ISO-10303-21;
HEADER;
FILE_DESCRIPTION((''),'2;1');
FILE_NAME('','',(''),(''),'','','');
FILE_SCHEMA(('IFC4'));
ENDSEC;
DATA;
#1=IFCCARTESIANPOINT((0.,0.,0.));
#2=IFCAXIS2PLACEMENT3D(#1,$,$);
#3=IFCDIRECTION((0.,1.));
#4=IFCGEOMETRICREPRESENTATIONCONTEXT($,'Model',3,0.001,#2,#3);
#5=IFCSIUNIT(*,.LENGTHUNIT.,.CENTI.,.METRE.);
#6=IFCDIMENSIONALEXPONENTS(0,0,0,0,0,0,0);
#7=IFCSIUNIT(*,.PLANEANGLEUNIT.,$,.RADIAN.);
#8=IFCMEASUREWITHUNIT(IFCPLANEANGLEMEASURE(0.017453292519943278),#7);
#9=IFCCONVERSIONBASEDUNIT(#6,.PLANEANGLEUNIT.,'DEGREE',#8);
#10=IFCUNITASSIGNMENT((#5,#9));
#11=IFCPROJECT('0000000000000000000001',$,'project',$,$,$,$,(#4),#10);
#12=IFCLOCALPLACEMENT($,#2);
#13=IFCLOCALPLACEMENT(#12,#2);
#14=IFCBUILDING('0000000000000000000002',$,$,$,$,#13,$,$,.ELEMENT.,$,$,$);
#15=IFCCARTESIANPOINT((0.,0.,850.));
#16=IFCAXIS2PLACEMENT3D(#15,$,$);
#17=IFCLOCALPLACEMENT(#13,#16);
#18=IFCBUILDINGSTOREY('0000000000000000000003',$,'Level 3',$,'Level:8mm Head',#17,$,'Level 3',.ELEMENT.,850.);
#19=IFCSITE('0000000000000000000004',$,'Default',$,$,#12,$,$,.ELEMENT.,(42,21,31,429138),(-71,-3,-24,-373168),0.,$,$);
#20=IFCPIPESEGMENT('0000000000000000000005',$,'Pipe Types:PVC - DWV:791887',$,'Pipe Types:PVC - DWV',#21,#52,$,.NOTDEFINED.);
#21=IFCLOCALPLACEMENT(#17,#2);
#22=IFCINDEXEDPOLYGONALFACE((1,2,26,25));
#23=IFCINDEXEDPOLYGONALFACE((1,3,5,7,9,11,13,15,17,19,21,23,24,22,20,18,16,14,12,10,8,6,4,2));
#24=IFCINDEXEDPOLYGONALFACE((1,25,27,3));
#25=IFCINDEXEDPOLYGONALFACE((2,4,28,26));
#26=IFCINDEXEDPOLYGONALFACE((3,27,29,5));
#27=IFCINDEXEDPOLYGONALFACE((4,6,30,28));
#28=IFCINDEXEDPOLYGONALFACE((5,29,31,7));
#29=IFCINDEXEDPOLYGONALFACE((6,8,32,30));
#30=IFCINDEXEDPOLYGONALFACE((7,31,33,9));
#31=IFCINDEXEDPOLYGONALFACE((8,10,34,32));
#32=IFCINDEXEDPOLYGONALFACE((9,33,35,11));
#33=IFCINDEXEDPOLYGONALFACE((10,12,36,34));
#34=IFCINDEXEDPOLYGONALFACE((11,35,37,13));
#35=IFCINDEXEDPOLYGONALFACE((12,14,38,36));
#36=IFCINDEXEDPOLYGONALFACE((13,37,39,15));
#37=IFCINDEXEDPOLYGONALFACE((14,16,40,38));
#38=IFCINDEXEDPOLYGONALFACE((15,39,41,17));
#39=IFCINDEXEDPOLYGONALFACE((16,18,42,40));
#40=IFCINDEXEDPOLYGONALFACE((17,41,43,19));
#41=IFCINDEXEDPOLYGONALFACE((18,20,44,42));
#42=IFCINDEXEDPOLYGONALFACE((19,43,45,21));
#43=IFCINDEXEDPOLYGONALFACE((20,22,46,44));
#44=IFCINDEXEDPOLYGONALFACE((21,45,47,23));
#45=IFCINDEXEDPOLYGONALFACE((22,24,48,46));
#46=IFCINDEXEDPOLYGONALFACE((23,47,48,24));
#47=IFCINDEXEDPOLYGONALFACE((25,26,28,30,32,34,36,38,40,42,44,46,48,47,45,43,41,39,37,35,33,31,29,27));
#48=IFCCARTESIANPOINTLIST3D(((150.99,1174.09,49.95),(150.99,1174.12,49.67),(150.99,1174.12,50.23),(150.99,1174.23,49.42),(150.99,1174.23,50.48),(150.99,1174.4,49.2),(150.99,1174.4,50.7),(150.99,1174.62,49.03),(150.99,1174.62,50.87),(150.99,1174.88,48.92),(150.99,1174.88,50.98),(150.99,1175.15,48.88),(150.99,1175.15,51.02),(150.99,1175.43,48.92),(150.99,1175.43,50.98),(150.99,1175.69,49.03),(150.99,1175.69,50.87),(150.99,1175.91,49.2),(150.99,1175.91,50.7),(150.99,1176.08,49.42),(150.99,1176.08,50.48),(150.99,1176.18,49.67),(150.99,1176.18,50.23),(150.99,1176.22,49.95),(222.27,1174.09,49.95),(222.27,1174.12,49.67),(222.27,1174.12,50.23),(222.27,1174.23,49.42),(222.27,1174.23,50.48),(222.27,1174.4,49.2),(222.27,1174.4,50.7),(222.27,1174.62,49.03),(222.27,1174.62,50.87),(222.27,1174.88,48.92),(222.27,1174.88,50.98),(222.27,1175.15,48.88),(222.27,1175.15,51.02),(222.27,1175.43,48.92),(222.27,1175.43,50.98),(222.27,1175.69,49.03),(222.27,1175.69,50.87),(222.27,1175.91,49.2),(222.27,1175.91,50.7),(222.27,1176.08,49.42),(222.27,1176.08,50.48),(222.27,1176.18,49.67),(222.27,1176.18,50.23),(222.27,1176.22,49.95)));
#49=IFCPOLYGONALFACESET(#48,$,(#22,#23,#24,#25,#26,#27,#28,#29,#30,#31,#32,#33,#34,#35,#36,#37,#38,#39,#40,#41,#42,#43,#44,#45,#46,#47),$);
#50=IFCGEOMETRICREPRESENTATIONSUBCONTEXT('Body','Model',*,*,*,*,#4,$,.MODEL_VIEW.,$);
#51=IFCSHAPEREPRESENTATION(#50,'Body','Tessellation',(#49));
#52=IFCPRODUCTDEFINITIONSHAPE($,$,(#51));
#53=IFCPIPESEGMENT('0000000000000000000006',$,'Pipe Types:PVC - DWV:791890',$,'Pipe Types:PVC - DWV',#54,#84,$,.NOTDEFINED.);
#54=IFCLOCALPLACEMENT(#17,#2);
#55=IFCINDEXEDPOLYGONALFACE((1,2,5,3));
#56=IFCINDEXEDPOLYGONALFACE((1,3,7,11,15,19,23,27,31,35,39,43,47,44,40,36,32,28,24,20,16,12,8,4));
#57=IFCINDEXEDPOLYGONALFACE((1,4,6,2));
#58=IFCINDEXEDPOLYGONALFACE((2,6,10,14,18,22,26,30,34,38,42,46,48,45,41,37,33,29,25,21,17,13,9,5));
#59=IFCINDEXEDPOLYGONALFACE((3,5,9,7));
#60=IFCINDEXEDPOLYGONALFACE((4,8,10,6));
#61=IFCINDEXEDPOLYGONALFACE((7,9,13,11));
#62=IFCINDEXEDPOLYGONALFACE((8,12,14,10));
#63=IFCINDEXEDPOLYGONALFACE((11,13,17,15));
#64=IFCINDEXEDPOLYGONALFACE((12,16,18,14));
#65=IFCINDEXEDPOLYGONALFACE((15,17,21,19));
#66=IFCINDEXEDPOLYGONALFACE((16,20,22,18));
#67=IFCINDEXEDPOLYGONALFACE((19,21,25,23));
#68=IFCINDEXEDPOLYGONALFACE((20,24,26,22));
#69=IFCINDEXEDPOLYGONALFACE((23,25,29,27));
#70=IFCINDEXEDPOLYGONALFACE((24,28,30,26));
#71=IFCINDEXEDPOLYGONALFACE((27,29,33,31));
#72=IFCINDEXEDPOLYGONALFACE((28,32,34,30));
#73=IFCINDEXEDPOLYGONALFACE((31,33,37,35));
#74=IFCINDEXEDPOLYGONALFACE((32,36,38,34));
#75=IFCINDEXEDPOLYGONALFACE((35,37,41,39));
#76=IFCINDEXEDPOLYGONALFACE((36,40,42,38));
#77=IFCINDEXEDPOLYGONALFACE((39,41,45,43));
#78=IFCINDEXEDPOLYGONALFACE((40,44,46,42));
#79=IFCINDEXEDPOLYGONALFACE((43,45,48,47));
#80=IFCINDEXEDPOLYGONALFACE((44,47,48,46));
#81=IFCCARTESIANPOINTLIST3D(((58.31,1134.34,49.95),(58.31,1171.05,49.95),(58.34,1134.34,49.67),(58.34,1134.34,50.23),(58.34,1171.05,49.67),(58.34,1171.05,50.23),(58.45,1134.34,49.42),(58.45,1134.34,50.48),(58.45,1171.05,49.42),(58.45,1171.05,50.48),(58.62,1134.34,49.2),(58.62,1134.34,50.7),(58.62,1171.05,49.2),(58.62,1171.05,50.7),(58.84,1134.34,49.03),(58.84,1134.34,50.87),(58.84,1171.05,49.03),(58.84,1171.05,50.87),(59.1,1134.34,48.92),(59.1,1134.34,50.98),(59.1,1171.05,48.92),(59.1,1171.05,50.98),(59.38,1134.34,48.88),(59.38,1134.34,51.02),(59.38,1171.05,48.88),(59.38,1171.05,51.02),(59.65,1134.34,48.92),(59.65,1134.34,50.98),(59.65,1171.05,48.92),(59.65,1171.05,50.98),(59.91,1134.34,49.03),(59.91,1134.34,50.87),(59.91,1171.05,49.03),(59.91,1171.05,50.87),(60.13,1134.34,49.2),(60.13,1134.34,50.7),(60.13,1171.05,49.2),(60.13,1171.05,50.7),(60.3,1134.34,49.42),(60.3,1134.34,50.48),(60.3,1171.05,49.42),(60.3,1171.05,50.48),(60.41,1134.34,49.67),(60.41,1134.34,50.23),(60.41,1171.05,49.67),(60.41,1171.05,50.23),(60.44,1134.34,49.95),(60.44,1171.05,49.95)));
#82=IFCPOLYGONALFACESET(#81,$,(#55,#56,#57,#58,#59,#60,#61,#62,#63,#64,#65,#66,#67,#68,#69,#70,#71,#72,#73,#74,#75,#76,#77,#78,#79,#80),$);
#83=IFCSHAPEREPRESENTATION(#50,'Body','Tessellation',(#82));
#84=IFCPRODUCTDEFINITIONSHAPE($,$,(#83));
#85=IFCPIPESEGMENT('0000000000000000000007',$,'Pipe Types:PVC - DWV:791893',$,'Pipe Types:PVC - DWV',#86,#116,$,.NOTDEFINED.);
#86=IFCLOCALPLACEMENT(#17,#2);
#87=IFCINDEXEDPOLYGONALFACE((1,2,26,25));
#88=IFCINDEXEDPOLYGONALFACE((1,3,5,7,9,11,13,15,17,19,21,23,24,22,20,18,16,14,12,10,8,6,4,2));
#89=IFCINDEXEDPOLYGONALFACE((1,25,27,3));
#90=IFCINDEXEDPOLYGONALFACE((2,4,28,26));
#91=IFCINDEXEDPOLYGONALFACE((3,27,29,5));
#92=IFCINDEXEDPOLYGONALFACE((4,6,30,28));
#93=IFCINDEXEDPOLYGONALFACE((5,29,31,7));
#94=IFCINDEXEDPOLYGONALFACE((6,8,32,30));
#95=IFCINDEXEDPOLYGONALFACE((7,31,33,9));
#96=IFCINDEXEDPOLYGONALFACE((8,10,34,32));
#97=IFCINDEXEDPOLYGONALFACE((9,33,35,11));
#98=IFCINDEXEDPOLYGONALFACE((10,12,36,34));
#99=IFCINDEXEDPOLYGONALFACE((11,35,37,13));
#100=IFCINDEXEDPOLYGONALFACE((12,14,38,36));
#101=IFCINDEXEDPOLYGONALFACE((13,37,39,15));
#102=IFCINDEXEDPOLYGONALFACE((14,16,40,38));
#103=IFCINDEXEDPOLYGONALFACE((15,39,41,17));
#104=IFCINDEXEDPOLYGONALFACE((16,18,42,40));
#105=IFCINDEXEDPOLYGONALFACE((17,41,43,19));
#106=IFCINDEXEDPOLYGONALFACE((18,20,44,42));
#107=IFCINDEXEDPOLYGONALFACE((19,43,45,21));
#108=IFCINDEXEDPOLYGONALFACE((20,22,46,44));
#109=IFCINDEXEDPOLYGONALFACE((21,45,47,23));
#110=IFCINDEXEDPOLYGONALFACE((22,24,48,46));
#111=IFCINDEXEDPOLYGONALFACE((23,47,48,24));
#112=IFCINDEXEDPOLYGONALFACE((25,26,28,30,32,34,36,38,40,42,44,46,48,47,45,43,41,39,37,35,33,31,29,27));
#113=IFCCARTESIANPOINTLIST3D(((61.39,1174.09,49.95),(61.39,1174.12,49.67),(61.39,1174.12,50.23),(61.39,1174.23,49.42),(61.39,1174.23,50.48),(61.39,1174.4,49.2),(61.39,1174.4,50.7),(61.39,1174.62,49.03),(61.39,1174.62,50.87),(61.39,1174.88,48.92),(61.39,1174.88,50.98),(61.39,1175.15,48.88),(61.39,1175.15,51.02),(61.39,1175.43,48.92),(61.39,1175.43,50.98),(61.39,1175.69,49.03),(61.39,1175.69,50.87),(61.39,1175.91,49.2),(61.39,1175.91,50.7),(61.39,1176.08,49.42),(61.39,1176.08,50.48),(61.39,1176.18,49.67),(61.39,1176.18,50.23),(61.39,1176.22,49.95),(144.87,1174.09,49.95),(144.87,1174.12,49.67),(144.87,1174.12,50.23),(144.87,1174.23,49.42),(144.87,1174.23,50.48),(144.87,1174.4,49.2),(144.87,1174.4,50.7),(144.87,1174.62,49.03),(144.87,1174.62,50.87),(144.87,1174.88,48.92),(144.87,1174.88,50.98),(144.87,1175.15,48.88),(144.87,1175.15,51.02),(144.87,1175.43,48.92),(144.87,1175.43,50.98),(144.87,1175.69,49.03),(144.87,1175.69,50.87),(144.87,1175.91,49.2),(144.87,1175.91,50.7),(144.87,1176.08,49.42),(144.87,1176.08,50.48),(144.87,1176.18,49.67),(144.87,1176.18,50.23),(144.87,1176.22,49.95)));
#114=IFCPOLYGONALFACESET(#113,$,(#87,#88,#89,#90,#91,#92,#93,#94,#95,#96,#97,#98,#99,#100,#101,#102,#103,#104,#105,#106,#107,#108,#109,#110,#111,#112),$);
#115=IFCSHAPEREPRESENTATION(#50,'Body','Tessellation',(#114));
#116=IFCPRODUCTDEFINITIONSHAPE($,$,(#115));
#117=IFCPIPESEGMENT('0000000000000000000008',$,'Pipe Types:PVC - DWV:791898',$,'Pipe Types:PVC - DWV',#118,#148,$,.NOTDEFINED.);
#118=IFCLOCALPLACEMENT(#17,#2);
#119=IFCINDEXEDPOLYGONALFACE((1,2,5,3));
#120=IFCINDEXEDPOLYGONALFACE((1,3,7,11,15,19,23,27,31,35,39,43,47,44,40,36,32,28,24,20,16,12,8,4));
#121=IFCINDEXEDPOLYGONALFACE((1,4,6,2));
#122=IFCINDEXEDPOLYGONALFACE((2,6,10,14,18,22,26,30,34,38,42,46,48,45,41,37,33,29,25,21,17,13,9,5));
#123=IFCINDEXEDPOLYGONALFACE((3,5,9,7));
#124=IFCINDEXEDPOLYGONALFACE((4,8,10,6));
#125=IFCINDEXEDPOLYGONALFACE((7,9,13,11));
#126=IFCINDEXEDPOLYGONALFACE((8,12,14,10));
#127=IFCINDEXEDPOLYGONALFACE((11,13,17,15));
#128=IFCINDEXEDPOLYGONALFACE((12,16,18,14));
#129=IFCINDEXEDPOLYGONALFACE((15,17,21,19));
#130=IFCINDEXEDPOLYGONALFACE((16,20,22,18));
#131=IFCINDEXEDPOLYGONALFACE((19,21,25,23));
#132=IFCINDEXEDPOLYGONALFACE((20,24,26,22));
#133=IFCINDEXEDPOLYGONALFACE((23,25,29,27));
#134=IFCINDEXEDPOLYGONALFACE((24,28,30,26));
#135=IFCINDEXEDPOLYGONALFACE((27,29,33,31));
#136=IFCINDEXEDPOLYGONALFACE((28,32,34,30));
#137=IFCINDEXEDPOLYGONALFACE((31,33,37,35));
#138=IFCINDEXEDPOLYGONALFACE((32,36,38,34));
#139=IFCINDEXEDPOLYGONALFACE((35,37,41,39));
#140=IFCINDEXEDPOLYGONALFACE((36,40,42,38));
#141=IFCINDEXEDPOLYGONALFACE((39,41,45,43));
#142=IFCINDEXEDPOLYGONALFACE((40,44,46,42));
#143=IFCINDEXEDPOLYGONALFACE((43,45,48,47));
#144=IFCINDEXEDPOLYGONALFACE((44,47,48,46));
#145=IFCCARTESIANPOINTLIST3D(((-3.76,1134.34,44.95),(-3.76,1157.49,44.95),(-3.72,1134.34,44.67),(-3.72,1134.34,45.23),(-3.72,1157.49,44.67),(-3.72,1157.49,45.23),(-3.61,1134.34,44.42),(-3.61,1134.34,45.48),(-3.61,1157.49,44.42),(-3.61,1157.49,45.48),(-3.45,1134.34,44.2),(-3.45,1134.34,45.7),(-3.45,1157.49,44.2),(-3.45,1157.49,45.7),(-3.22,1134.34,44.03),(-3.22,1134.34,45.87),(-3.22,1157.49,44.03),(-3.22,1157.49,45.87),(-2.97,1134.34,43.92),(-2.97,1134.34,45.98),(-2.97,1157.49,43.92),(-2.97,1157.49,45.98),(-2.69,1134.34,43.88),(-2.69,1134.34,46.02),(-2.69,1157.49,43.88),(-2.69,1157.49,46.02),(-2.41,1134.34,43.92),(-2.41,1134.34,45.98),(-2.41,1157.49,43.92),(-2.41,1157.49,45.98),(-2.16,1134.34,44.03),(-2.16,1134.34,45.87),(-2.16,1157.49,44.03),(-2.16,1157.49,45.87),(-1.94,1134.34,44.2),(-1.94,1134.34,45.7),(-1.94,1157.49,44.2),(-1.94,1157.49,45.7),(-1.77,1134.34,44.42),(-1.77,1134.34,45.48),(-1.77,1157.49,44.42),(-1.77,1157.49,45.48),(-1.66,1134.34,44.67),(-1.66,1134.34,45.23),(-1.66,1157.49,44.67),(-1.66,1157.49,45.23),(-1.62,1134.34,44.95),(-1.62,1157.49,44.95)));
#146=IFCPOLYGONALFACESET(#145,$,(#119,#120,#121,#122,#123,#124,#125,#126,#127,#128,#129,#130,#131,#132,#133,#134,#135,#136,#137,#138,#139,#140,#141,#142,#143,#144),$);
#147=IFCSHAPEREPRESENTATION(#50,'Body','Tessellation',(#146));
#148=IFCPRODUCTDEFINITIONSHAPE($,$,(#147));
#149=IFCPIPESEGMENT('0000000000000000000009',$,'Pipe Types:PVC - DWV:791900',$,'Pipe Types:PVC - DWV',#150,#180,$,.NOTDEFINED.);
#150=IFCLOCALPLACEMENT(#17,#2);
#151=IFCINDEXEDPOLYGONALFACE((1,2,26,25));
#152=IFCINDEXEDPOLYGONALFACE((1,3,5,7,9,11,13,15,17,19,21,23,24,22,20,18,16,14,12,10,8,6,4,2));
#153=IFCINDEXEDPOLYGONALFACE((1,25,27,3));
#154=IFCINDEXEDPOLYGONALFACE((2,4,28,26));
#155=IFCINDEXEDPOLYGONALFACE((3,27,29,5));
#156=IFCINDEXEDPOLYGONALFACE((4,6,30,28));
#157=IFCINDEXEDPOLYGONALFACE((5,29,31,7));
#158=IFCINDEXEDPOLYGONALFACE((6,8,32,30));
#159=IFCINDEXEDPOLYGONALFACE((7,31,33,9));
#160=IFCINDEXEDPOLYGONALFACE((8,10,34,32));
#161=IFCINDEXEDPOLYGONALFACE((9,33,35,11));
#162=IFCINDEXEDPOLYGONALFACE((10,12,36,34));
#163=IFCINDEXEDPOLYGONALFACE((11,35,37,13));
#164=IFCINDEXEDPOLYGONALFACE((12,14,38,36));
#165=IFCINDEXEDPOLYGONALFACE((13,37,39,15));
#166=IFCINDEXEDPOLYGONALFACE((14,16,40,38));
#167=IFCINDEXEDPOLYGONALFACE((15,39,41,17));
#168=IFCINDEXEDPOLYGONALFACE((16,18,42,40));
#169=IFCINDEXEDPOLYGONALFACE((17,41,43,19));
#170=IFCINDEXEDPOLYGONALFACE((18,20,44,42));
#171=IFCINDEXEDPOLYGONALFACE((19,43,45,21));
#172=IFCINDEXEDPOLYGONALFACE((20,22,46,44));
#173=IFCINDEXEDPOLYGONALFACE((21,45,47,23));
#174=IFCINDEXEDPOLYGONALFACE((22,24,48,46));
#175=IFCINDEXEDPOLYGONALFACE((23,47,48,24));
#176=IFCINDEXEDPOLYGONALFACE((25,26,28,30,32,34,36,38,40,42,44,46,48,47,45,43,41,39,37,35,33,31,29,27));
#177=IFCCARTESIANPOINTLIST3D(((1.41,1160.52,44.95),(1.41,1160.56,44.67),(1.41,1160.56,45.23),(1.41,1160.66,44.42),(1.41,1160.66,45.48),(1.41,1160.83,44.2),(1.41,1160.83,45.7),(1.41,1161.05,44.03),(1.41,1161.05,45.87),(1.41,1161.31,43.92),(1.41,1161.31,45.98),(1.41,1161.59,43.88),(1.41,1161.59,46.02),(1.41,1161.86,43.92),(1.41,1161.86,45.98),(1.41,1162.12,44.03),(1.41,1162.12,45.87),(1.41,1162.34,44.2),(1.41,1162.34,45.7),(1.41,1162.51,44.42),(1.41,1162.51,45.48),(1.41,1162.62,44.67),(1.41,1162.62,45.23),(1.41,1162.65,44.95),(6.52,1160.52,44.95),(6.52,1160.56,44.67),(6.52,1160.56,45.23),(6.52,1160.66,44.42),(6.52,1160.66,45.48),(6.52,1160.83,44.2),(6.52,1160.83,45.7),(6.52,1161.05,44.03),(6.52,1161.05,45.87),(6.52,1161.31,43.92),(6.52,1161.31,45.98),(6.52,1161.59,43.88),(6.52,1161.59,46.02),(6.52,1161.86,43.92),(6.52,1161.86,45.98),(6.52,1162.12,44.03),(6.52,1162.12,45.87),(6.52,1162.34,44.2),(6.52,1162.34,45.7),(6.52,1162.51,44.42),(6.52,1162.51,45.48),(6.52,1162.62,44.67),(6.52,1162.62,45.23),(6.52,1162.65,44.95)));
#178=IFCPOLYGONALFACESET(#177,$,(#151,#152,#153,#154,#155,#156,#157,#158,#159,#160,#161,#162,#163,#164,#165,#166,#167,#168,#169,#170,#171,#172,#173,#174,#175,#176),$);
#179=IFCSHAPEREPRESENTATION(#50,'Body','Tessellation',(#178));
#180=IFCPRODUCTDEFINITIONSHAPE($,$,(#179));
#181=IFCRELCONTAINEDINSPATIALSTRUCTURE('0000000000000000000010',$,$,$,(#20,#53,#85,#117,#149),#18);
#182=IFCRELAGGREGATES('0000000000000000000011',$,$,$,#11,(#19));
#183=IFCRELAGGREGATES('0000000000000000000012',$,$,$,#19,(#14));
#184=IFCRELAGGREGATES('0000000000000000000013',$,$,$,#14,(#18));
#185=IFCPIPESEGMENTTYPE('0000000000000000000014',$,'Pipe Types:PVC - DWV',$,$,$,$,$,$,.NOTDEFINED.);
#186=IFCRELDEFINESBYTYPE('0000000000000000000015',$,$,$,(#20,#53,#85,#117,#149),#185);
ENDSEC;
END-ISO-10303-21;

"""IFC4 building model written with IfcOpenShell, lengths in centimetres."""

from ifc_helpers import new_model, entity, si_unit, converted_unit, direction, frame, origin, place, context, subcontext, project, spatial, arc, indexed_curve, outline, extrude, type_object, element, save


model = new_model("IFC4")

# Units and contexts
model_context = context("Model", 3, precision=0.001, world=origin(), true_north=direction((0.0, 1.0)))
body_context = subcontext(model_context, "Body", "Model", "MODEL_VIEW")
ifc_project = project(units=[si_unit("LENGTHUNIT", "METRE", prefix="CENTI"), converted_unit("PLANEANGLEUNIT", "DEGREE", entity("IfcPlaneAngleMeasure", 0.017453292519943278), si_unit("PLANEANGLEUNIT", "RADIAN"), dimensions=[0, 0, 0, 0, 0, 0, 0])], contexts=[model_context])

# Site, building, storey
site_placement = place(None, origin())
site = spatial("IfcSite", under=ifc_project, at=site_placement, Name="Default", CompositionType="ELEMENT", RefLatitude=(42, 21, 31, 429138), RefLongitude=(-71, -3, -24, -373168), RefElevation=0.0)
building_placement = place(site_placement, origin())
building = spatial("IfcBuilding", under=site, at=building_placement, CompositionType="ELEMENT")
storey_placement = place(building_placement, frame((0.0, 0.0, 850.0)))
storey = spatial("IfcBuildingStorey", under=building, at=storey_placement, Name="Level 3", ObjectType="Level:8mm Head", LongName="Level 3", CompositionType="ELEMENT", Elevation=850.0)

# Pipe segments
pipe_segment_type = type_object("IfcPipeSegmentType", Name="Pipe Types:PVC - DWV", PredefinedType="NOTDEFINED")
pipe_segment_1_placement = place(storey_placement, origin())
element("IfcPipeSegment", 1, at=pipe_segment_1_placement, inside=storey, type_object=pipe_segment_type, Name="Pipe Types:PVC - DWV:791887", ObjectType="Pipe Types:PVC - DWV", PredefinedType="NOTDEFINED", context=body_context, shape_type="SweptSolid", body=[
    extrude(outline(indexed_curve([(1.07, 0.0), (0.75, 0.75), (0.0, 1.07), (-0.75, 0.75), (-1.07, 0.0), (-0.75, -0.75), (0.0, -1.07), (0.75, -0.75)], segments=[arc(1, 2, 3), arc(3, 4, 5), arc(5, 6, 7), arc(7, 8, 1)], self_intersect=False)), frame((150.99, 1175.15, 49.95), z_axis=(1.0, 0.0, 0.0), x_axis=(0.0, 1.0, 0.0)), (0.0, 0.0, 1.0), 71.29),
])
pipe_segment_2_placement = place(storey_placement, origin())
element("IfcPipeSegment", 2, at=pipe_segment_2_placement, inside=storey, type_object=pipe_segment_type, Name="Pipe Types:PVC - DWV:791890", ObjectType="Pipe Types:PVC - DWV", PredefinedType="NOTDEFINED", context=body_context, shape_type="SweptSolid", body=[
    extrude(outline(indexed_curve([(1.07, 0.0), (0.75, 0.75), (0.0, 1.07), (-0.75, 0.75), (-1.07, 0.0), (-0.75, -0.75), (0.0, -1.07), (0.75, -0.75)], segments=[arc(1, 2, 3), arc(3, 4, 5), arc(5, 6, 7), arc(7, 8, 1)], self_intersect=False)), frame((59.38, 1134.34, 49.95), z_axis=(0.0, 1.0, 0.0), x_axis=(-1.0, 0.0, 0.0)), (0.0, 0.0, 1.0), 36.71),
])
pipe_segment_3_placement = place(storey_placement, origin())
element("IfcPipeSegment", 3, at=pipe_segment_3_placement, inside=storey, type_object=pipe_segment_type, Name="Pipe Types:PVC - DWV:791893", ObjectType="Pipe Types:PVC - DWV", PredefinedType="NOTDEFINED", context=body_context, shape_type="SweptSolid", body=[
    extrude(outline(indexed_curve([(1.07, 0.0), (0.75, 0.75), (0.0, 1.07), (-0.75, 0.75), (-1.07, 0.0), (-0.75, -0.75), (0.0, -1.07), (0.75, -0.75)], segments=[arc(1, 2, 3), arc(3, 4, 5), arc(5, 6, 7), arc(7, 8, 1)], self_intersect=False)), frame((61.39, 1175.15, 49.95), z_axis=(1.0, 0.0, 0.0), x_axis=(0.0, 1.0, 0.0)), (0.0, 0.0, 1.0), 83.49),
])
pipe_segment_4_placement = place(storey_placement, origin())
element("IfcPipeSegment", 4, at=pipe_segment_4_placement, inside=storey, type_object=pipe_segment_type, Name="Pipe Types:PVC - DWV:791898", ObjectType="Pipe Types:PVC - DWV", PredefinedType="NOTDEFINED", context=body_context, shape_type="SweptSolid", body=[
    extrude(outline(indexed_curve([(1.07, 0.0), (0.75, 0.75), (0.0, 1.07), (-0.75, 0.75), (-1.07, 0.0), (-0.75, -0.75), (0.0, -1.07), (0.75, -0.75)], segments=[arc(1, 2, 3), arc(3, 4, 5), arc(5, 6, 7), arc(7, 8, 1)], self_intersect=False)), frame((-2.69, 1134.34, 44.95), z_axis=(0.0, 1.0, 0.0), x_axis=(1.0, 0.0, 0.0)), (0.0, 0.0, 1.0), 23.14),
])
pipe_segment_5_placement = place(storey_placement, origin())
element("IfcPipeSegment", 5, at=pipe_segment_5_placement, inside=storey, type_object=pipe_segment_type, Name="Pipe Types:PVC - DWV:791900", ObjectType="Pipe Types:PVC - DWV", PredefinedType="NOTDEFINED", context=body_context, shape_type="SweptSolid", body=[
    extrude(outline(indexed_curve([(1.07, 0.0), (0.75, 0.75), (0.0, 1.07), (-0.75, 0.75), (-1.07, 0.0), (-0.75, -0.75), (0.0, -1.07), (0.75, -0.75)], segments=[arc(1, 2, 3), arc(3, 4, 5), arc(5, 6, 7), arc(7, 8, 1)], self_intersect=False)), frame((1.41, 1161.59, 44.95), z_axis=(1.0, 0.0, 0.0), x_axis=(0.0, -1.0, 0.0)), (0.0, 0.0, 1.0), 5.11),
])

save(model, "model.ifc")
